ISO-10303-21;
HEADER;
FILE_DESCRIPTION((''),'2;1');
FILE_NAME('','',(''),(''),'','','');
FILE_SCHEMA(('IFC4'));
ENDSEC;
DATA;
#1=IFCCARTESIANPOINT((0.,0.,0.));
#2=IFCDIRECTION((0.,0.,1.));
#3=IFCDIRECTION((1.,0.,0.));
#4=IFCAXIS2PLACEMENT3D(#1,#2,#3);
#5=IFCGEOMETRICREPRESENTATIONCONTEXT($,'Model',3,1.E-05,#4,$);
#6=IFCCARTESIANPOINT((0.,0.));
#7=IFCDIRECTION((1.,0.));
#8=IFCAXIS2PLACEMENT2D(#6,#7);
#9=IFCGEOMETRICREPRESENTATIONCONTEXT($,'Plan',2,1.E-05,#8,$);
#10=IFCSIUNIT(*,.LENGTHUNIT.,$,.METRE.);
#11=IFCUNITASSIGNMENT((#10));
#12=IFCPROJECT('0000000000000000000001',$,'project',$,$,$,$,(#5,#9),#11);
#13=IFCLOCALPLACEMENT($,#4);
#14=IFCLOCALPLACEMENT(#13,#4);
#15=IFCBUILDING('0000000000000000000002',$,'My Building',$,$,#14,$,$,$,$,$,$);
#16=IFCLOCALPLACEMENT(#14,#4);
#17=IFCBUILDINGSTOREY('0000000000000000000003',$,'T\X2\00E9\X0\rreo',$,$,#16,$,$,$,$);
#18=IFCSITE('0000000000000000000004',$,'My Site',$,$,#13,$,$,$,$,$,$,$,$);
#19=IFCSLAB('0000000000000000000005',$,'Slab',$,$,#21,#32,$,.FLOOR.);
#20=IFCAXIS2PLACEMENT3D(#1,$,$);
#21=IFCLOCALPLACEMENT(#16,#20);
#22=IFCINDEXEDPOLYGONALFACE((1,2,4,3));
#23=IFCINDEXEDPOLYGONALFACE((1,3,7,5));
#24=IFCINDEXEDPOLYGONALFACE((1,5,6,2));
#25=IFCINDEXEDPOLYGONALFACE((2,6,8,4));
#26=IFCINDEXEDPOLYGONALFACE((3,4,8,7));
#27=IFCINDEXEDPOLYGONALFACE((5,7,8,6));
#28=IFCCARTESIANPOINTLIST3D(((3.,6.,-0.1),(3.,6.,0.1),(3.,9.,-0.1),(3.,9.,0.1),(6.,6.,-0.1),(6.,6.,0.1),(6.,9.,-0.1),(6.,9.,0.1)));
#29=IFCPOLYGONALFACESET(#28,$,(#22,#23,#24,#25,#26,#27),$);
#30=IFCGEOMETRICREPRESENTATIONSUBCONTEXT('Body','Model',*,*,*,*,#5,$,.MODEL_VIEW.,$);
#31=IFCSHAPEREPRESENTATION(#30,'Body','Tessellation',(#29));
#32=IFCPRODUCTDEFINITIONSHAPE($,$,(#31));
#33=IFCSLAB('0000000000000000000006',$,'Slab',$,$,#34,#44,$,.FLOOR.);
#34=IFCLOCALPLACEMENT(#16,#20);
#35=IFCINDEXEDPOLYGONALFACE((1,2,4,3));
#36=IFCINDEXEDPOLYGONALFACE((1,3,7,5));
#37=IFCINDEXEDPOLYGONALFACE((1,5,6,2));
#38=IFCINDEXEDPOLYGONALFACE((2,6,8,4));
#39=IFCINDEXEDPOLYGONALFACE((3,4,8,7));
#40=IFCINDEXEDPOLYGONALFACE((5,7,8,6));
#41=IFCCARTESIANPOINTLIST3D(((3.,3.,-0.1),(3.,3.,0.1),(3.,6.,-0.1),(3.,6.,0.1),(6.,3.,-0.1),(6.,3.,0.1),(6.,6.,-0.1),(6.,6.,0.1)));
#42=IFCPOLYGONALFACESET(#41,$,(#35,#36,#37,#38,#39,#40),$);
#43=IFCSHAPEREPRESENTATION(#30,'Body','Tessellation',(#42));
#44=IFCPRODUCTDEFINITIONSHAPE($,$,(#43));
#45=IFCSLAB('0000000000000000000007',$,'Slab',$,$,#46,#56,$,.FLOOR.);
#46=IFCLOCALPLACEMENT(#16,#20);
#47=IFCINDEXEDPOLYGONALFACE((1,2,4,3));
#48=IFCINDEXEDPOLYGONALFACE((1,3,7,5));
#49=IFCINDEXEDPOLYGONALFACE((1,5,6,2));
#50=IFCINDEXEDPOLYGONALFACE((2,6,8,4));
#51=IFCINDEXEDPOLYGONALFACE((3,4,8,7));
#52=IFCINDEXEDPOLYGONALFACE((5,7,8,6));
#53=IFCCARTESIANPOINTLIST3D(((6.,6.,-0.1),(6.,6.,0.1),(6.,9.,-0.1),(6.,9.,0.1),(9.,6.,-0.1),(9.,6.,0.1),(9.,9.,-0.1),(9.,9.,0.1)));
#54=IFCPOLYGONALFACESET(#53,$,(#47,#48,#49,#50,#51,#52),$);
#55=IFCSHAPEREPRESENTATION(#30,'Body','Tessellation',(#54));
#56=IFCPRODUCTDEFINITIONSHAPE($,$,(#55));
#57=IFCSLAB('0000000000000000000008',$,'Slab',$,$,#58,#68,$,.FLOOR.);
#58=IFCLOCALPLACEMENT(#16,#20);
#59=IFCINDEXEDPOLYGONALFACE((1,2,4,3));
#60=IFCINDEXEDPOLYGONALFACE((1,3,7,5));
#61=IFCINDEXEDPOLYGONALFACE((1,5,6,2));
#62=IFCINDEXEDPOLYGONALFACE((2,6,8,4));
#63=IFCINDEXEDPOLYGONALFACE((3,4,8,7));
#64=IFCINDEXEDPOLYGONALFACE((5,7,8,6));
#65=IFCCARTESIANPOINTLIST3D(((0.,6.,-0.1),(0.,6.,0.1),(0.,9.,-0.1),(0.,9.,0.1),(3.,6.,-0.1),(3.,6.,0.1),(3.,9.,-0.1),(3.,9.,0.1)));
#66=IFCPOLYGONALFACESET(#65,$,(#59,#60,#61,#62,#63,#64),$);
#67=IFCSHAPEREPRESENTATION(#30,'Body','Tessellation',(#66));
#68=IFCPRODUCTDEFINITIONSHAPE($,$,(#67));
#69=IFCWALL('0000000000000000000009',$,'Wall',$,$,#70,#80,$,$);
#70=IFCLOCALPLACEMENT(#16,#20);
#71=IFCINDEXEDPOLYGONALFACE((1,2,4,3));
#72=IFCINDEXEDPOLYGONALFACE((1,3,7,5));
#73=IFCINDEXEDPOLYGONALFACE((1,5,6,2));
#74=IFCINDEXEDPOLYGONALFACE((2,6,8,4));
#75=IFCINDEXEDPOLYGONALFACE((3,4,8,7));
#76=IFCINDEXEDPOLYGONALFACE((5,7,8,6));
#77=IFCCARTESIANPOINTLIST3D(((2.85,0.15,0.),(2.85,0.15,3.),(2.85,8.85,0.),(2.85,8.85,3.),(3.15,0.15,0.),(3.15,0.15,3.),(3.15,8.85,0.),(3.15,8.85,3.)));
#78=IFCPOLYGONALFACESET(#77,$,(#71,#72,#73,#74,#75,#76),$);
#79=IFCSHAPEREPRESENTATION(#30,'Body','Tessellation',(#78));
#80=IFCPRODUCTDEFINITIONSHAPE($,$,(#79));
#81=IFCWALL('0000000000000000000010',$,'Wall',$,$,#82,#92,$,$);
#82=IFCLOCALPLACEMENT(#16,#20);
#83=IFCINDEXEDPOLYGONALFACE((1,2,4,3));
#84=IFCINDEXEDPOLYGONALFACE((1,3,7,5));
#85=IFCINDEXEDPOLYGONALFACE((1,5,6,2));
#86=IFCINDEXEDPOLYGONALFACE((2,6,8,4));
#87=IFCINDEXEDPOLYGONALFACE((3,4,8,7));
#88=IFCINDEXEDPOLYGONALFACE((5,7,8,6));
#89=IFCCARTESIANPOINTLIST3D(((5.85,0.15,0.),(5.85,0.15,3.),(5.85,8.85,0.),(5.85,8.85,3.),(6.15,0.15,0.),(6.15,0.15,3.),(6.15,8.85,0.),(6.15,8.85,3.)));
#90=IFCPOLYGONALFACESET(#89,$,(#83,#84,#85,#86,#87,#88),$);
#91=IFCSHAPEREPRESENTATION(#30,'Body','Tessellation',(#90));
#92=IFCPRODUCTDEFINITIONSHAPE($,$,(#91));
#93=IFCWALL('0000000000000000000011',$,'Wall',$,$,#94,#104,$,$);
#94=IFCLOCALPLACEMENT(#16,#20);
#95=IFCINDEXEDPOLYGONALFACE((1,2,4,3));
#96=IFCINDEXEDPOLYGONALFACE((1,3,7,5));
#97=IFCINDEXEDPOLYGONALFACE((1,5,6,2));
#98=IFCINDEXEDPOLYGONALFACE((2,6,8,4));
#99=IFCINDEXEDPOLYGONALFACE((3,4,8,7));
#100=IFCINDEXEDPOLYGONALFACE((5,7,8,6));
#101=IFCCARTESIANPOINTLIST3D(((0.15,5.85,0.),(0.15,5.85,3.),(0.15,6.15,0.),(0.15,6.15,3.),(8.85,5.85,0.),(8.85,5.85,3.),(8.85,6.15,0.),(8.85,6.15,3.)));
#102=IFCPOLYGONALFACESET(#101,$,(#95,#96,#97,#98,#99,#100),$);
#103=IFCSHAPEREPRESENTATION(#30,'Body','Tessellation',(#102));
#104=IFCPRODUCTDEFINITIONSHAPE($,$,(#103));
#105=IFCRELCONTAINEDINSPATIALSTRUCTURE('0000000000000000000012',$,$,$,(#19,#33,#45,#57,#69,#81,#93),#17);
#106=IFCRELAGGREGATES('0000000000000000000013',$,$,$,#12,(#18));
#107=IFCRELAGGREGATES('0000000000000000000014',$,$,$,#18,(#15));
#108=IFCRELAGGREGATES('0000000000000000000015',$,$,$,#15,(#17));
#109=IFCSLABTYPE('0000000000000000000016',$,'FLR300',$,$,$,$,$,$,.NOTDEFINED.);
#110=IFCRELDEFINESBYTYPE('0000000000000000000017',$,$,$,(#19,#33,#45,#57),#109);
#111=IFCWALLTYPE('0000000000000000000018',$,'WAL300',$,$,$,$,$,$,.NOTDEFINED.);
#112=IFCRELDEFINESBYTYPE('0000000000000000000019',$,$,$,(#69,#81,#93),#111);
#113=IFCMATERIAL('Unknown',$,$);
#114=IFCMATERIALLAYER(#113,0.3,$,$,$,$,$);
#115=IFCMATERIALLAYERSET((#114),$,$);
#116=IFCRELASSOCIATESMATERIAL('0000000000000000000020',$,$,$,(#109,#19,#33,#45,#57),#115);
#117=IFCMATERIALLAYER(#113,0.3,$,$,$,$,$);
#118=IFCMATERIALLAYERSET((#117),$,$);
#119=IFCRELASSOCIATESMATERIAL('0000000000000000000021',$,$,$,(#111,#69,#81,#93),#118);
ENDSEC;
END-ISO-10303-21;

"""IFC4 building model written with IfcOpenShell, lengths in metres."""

from ifc_helpers import new_model, si_unit, frame, origin, origin_with_axes, origin_2d_with_axis, place, context, subcontext, project, spatial, polyline, line, indexed_curve, outline, extrude, material, layer, layer_set, layer_usage, type_object, element, save


model = new_model("IFC4")

# Units and contexts
model_context = context("Model", 3, precision=1e-05, world=origin_with_axes())
plan_context = context("Plan", 2, precision=1e-05, world=origin_2d_with_axis())
body_context_1 = subcontext(model_context, "Body", "Model", "MODEL_VIEW")
ifc_project = project(units=[si_unit("LENGTHUNIT", "METRE")], contexts=[model_context, plan_context])

# Site, building, storey
site_placement = place(None, origin_with_axes())
site = spatial("IfcSite", under=ifc_project, at=site_placement, Name="My Site")
building_placement = place(site_placement, origin_with_axes())
building = spatial("IfcBuilding", under=site, at=building_placement, Name="My Building")
storey_placement = place(building_placement, origin_with_axes())
storey = spatial("IfcBuildingStorey", under=building, at=storey_placement, Name="Térreo")

# Slabs
ifc_material = material(Name="Unknown")
ifc_layer_1 = layer(ifc_material, 0.3)
ifc_layer_set_1 = layer_set([ifc_layer_1])
ifc_layer_usage_1 = layer_usage(ifc_layer_set_1, "AXIS3", "POSITIVE", 0.0)
slab_type = type_object("IfcSlabType", Name="FLR300", PredefinedType="NOTDEFINED", material=ifc_layer_set_1)
slab_1_placement = place(storey_placement, frame((4.5, 7.5, -0.1), z_axis=(0.0, 0.0, 1.0), x_axis=(1.0, 0.0, 0.0)))
element("IfcSlab", 1, at=slab_1_placement, inside=storey, type_object=slab_type, material=ifc_layer_usage_1, Name="Slab", PredefinedType="FLOOR", context=body_context_1, shape_type="SweptSolid", body=[
    extrude(outline(polyline([(-1.5, 1.5), (-1.5, -1.5), (1.5, -1.5), (1.5, 1.5), (-1.5, 1.5)])), origin(), (0.0, 0.0, 1.0), 0.2),
])
ifc_layer_usage_2 = layer_usage(ifc_layer_set_1, "AXIS3", "POSITIVE", 0.0)
slab_2_placement = place(storey_placement, frame((4.5, 4.5, -0.1), z_axis=(0.0, 0.0, 1.0), x_axis=(1.0, 0.0, 0.0)))
element("IfcSlab", 2, at=slab_2_placement, inside=storey, type_object=slab_type, material=ifc_layer_usage_2, Name="Slab", PredefinedType="FLOOR", context=body_context_1, shape_type="SweptSolid", body=[
    extrude(outline(polyline([(-1.5, 1.5), (-1.5, -1.5), (1.5, -1.5), (1.5, 1.5), (-1.5, 1.5)])), origin(), (0.0, 0.0, 1.0), 0.2),
])
ifc_layer_usage_3 = layer_usage(ifc_layer_set_1, "AXIS3", "POSITIVE", 0.0)
slab_3_placement = place(storey_placement, frame((7.5, 7.5, -0.1), z_axis=(0.0, 0.0, 1.0), x_axis=(1.0, 0.0, 0.0)))
element("IfcSlab", 3, at=slab_3_placement, inside=storey, type_object=slab_type, material=ifc_layer_usage_3, Name="Slab", PredefinedType="FLOOR", context=body_context_1, shape_type="SweptSolid", body=[
    extrude(outline(polyline([(-1.5, 1.5), (-1.5, -1.5), (1.5, -1.5), (1.5, 1.5), (-1.5, 1.5)])), origin(), (0.0, 0.0, 1.0), 0.2),
])
ifc_layer_usage_4 = layer_usage(ifc_layer_set_1, "AXIS3", "POSITIVE", 0.0)
slab_4_placement = place(storey_placement, frame((1.5, 7.5, -0.1), z_axis=(0.0, 0.0, 1.0), x_axis=(1.0, 0.0, 0.0)))
element("IfcSlab", 4, at=slab_4_placement, inside=storey, type_object=slab_type, material=ifc_layer_usage_4, Name="Slab", PredefinedType="FLOOR", context=body_context_1, shape_type="SweptSolid", body=[
    extrude(outline(polyline([(-1.5, 1.5), (-1.5, -1.5), (1.5, -1.5), (1.5, 1.5), (-1.5, 1.5)])), origin(), (0.0, 0.0, 1.0), 0.2),
])

# Walls
ifc_layer_2 = layer(ifc_material, 0.3)
ifc_layer_set_2 = layer_set([ifc_layer_2])
ifc_layer_usage_5 = layer_usage(ifc_layer_set_2, "AXIS2", "POSITIVE", -0.15)
wall_type = type_object("IfcWallType", Name="WAL300", PredefinedType="NOTDEFINED", material=ifc_layer_set_2)
wall_1_placement = place(storey_placement, frame((3.0, 9.0, 0.0), z_axis=(0.0, 0.0, 1.0), x_axis=(0.0, -1.0, 0.0)))
element("IfcWall", 5, at=wall_1_placement, inside=storey, type_object=wall_type, material=ifc_layer_usage_5, Name="Wall", context=body_context_1, shape_type="SweptSolid", body=[
    extrude(outline(indexed_curve([(0.15, -0.15), (0.15, 0.15), (8.85, 0.15), (8.85, -0.15)], segments=[line(1, 2, 3, 4, 1)])), origin_with_axes(), (0.0, 0.0, 1.0), 3.0),
])
ifc_layer_usage_6 = layer_usage(ifc_layer_set_2, "AXIS2", "POSITIVE", -0.15)
wall_2_placement = place(storey_placement, frame((6.0, 9.0, 0.0), z_axis=(0.0, 0.0, 1.0), x_axis=(0.0, -1.0, 0.0)))
element("IfcWall", 6, at=wall_2_placement, inside=storey, type_object=wall_type, material=ifc_layer_usage_6, Name="Wall", context=body_context_1, shape_type="SweptSolid", body=[
    extrude(outline(indexed_curve([(0.15, -0.15), (0.15, 0.15), (8.85, 0.15), (8.85, -0.15)], segments=[line(1, 2, 3, 4, 1)])), origin_with_axes(), (0.0, 0.0, 1.0), 3.0),
])

# Wall
ifc_layer_usage_7 = layer_usage(ifc_layer_set_2, "AXIS2", "POSITIVE", -0.15)
wall_3_placement = place(storey_placement, frame((0.0, 6.0, 0.0), z_axis=(0.0, 0.0, 1.0), x_axis=(1.0, 0.0, 0.0)))
element("IfcWall", 7, at=wall_3_placement, inside=storey, type_object=wall_type, material=ifc_layer_usage_7, Name="Wall", context=body_context_1, shape_type="SweptSolid", body=[
    extrude(outline(indexed_curve([(0.15, -0.15), (0.15, 0.15), (8.85, 0.15), (8.85, -0.15)], segments=[line(1, 2, 3, 4, 1)])), origin_with_axes(), (0.0, 0.0, 1.0), 3.0),
])

save(model, "model.ifc")
